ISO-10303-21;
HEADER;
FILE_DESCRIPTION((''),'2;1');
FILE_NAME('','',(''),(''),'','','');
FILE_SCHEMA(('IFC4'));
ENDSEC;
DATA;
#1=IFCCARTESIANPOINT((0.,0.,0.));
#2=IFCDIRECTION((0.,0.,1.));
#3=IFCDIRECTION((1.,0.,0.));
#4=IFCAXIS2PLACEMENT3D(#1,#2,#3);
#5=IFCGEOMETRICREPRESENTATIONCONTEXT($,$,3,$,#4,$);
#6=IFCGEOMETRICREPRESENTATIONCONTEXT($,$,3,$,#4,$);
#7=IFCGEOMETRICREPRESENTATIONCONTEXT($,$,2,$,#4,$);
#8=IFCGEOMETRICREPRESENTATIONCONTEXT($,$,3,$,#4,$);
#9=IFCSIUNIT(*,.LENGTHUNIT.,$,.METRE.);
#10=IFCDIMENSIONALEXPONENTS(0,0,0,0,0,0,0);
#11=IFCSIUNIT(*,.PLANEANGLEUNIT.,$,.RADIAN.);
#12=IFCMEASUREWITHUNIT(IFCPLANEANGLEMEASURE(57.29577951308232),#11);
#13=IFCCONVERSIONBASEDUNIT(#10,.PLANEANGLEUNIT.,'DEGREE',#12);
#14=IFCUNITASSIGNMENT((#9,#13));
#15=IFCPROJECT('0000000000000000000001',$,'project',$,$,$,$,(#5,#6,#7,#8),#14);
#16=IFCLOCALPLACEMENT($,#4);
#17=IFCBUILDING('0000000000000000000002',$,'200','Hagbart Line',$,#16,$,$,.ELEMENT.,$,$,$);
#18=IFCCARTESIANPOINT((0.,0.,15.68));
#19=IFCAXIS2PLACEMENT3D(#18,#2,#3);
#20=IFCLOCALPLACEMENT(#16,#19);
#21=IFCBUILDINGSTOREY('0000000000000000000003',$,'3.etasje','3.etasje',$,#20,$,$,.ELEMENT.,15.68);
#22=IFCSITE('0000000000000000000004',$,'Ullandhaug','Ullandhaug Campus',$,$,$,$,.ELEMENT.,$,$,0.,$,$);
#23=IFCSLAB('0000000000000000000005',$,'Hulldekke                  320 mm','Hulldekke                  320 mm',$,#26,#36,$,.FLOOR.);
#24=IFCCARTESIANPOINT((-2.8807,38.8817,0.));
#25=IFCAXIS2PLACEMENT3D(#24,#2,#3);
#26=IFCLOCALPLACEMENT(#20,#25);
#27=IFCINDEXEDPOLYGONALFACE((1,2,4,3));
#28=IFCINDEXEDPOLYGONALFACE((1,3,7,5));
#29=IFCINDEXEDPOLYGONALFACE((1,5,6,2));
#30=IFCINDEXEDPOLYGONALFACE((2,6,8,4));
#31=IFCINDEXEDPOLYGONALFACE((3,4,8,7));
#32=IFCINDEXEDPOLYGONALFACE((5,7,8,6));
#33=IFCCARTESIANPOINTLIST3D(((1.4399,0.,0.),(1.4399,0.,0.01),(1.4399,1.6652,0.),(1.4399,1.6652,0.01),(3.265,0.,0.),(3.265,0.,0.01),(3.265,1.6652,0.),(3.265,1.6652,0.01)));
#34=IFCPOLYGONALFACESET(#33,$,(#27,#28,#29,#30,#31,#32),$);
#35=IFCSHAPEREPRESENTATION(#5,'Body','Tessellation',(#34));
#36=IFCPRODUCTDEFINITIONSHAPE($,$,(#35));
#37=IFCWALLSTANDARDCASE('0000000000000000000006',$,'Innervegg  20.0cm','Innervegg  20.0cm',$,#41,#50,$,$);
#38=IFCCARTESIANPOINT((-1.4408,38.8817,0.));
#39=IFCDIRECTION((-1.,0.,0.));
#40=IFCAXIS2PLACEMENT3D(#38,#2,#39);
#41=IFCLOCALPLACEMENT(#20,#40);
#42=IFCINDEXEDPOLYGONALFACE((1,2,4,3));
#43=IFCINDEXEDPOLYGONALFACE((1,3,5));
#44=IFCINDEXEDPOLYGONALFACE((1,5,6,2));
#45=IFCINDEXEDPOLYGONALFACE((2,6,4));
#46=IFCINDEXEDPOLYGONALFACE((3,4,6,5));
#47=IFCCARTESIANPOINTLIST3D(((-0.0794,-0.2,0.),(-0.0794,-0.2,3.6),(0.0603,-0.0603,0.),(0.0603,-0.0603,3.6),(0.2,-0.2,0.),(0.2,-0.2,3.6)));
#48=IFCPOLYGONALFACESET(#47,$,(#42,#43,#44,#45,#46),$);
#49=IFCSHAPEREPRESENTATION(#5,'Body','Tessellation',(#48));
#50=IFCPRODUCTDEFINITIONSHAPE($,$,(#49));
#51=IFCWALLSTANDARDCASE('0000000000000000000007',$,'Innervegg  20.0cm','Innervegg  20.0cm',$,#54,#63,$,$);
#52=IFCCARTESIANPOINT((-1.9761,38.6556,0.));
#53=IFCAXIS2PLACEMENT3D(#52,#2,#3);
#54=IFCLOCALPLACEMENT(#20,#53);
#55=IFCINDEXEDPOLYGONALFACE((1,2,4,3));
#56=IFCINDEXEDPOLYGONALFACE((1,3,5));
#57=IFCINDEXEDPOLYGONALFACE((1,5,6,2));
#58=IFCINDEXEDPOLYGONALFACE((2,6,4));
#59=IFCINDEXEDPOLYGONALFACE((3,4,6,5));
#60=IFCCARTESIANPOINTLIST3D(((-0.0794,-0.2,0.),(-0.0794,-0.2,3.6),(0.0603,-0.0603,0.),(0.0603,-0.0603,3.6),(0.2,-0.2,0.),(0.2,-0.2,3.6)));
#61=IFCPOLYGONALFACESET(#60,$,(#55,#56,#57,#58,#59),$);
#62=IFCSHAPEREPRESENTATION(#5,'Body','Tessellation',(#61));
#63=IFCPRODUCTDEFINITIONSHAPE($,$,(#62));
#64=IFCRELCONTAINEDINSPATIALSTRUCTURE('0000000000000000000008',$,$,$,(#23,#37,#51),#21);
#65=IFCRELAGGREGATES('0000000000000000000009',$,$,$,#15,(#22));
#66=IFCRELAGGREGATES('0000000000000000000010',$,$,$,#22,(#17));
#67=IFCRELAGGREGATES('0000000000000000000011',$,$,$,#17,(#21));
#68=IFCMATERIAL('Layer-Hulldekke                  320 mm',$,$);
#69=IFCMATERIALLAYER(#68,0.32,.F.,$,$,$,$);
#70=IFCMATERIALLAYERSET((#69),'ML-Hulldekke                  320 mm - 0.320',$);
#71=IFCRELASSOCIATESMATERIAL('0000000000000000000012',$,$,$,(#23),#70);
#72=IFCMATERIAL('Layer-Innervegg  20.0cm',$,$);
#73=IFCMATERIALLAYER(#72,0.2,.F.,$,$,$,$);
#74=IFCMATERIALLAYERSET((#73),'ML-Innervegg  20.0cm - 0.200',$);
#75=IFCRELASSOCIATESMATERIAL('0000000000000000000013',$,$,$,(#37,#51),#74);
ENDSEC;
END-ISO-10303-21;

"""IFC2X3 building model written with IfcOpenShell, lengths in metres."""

from ifc_helpers import new_model, entity, si_unit, converted_unit, frame, origin_with_axes, place, context, project, spatial, polyline, outline, extrude, material, layer, layer_set, layer_usage, element, save


model = new_model("IFC2X3")

# Units and contexts
context_of_model_1 = context(None, 3, world=origin_with_axes())
context_of_model_2 = context(None, 3, world=origin_with_axes())
context_of_model_3 = context(None, 2, world=origin_with_axes())
context_of_model_4 = context(None, 3, world=origin_with_axes())
ifc_project = project(units=[si_unit("LENGTHUNIT", "METRE"), converted_unit("PLANEANGLEUNIT", "DEGREE", entity("IfcPlaneAngleMeasure", 57.29577951308232), si_unit("PLANEANGLEUNIT", "RADIAN"), dimensions=[0, 0, 0, 0, 0, 0, 0])], contexts=[context_of_model_1, context_of_model_2, context_of_model_3, context_of_model_4])

# Site, building, storey
site = spatial("IfcSite", under=ifc_project, Name="Ullandhaug", Description="Ullandhaug Campus", CompositionType="ELEMENT", RefElevation=0.0)
building_placement = place(None, origin_with_axes())
building = spatial("IfcBuilding", under=site, at=building_placement, Name="200", Description="Hagbart Line", CompositionType="ELEMENT")
storey_placement = place(building_placement, frame((0.0, 0.0, 15.68), z_axis=(0.0, 0.0, 1.0), x_axis=(1.0, 0.0, 0.0)))
storey = spatial("IfcBuildingStorey", under=building, at=storey_placement, Name="3.etasje", Description="3.etasje", CompositionType="ELEMENT", Elevation=15.68)

# Slab
ifc_material_1 = material(Name="Layer-Hulldekke                  320 mm")
ifc_layer_1 = layer(ifc_material_1, 0.32, ventilated=False)
ifc_layer_set_1 = layer_set([ifc_layer_1], Name="ML-Hulldekke                  320 mm - 0.320")
ifc_layer_usage_1 = layer_usage(ifc_layer_set_1, "AXIS2", "POSITIVE", 0.0)
slab_1_placement = place(storey_placement, frame((-2.8807, 38.8817, 0.0), z_axis=(0.0, 0.0, 1.0), x_axis=(1.0, 0.0, 0.0)))
element("IfcSlab", 1, at=slab_1_placement, inside=storey, material=ifc_layer_usage_1, Name="Hulldekke                  320 mm", Description="Hulldekke                  320 mm", PredefinedType="FLOOR", context=context_of_model_1, shape_type="SweptSolid", body=[
    extrude(outline(polyline([(0.0, 0.0), (3.265, 0.0), (3.265, 1.6652), (1.4399, 1.6652), (1.4399, 0.0), (1.3193, 0.0), (1.3193, 1.6652), (0.0, 1.6652), (0.0, 0.0)])), origin_with_axes(), (0.0, 0.0, 1.0), 0.01),
])

# Shared definitions
ifc_material_2 = material(Name="Layer-Innervegg  20.0cm")
ifc_layer_2 = layer(ifc_material_2, 0.2, ventilated=False)
ifc_layer_set_2 = layer_set([ifc_layer_2], Name="ML-Innervegg  20.0cm - 0.200")
ifc_layer_usage_2 = layer_usage(ifc_layer_set_2, "AXIS2", "POSITIVE", 0.0)

# Walls
wall_1_placement = place(storey_placement, frame((-1.4408, 38.8817, 0.0), z_axis=(0.0, 0.0, 1.0), x_axis=(-1.0, 0.0, 0.0)))
element("IfcWallStandardCase", 2, at=wall_1_placement, inside=storey, material=ifc_layer_usage_2, Name="Innervegg  20.0cm", Description="Innervegg  20.0cm", context=context_of_model_1, shape_type="SweptSolid", body=[
    extrude(outline(polyline([(0.0, 0.0), (0.1206, 0.0), (-0.0794, 0.2), (0.2, 0.2), (0.0, 0.0)])), frame((0.0, 0.0, 0.0), z_axis=(0.0, 0.0, -1.0), x_axis=(1.0, 0.0, 0.0)), (0.0, 0.0, -1.0), 3.6),
])
wall_2_placement = place(storey_placement, frame((-1.9761, 38.6556, 0.0), z_axis=(0.0, 0.0, 1.0), x_axis=(1.0, 0.0, 0.0)))
element("IfcWallStandardCase", 3, at=wall_2_placement, inside=storey, material=ifc_layer_usage_2, Name="Innervegg  20.0cm", Description="Innervegg  20.0cm", context=context_of_model_1, shape_type="SweptSolid", body=[
    extrude(outline(polyline([(0.0, 0.0), (0.1206, 0.0), (-0.0794, 0.2), (0.2, 0.2), (0.0, 0.0)])), frame((0.0, 0.0, 0.0), z_axis=(0.0, 0.0, -1.0), x_axis=(1.0, 0.0, 0.0)), (0.0, 0.0, -1.0), 3.6),
])

save(model, "model.ifc")
